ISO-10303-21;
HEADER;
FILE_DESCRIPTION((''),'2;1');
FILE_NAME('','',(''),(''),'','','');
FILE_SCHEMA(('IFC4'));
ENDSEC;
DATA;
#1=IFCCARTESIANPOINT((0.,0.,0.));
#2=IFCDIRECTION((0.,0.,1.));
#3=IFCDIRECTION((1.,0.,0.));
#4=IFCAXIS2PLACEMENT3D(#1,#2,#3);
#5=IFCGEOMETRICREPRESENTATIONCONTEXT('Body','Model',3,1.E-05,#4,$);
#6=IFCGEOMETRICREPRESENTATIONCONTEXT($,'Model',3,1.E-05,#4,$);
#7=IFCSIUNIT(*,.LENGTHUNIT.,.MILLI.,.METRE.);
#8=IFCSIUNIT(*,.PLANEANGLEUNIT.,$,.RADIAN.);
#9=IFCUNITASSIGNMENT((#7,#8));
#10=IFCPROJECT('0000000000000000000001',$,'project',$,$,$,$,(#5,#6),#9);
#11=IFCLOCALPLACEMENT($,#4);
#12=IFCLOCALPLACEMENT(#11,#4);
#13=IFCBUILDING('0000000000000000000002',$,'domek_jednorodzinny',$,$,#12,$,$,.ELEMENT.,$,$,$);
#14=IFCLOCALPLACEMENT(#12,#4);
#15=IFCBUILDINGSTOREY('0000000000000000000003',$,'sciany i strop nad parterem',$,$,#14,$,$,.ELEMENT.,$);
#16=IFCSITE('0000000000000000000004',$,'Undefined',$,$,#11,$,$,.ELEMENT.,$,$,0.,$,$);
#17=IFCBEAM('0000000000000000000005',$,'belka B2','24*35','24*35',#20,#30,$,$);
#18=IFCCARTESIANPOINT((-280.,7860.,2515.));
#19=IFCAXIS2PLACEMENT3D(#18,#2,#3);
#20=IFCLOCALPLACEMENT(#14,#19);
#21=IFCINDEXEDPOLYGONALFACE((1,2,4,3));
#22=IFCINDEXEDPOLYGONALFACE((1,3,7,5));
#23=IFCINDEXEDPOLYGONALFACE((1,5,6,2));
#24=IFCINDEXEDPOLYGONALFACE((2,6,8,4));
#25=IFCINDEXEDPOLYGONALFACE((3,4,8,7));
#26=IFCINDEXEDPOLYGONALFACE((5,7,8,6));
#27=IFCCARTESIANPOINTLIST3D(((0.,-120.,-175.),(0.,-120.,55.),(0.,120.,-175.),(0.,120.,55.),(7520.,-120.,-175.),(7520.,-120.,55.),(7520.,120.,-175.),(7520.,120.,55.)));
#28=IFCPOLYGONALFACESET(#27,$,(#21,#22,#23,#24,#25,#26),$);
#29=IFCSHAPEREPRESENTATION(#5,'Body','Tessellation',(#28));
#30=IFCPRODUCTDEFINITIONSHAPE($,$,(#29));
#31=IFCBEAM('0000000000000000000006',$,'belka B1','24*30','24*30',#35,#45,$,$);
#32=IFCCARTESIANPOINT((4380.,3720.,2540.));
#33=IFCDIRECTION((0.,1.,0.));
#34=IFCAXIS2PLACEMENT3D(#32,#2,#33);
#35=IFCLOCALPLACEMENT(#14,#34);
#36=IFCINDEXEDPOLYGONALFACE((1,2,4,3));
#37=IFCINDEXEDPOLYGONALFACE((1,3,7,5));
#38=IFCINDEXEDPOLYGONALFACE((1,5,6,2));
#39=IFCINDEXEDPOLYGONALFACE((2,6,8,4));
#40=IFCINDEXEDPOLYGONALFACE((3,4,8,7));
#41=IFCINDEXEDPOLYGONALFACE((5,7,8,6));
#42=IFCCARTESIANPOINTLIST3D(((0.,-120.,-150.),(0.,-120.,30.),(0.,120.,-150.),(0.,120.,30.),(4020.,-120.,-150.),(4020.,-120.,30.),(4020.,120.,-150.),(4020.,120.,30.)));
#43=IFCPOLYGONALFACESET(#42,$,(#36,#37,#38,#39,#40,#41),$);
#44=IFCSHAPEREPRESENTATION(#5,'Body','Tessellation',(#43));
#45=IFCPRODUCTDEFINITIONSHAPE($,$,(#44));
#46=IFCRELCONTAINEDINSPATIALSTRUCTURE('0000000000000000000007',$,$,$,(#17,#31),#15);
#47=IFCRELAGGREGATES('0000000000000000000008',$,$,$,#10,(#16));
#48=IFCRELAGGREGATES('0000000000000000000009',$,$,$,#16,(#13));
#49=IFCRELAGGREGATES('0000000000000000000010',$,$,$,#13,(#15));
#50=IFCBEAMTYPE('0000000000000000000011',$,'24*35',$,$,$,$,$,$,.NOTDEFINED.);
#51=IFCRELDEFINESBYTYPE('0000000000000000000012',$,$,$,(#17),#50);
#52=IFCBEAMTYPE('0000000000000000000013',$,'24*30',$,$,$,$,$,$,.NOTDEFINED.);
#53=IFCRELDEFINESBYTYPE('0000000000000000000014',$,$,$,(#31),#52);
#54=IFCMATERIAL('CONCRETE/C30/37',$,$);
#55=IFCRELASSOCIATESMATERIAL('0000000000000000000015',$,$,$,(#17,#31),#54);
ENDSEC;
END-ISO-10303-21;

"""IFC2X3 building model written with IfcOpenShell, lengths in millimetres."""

from ifc_helpers import new_model, si_unit, frame, origin_with_axes, origin_2d_with_axis, place, context, project, spatial, rectangle, extrude, clip, halfspace, material, type_object, element, save


model = new_model("IFC2X3")

# Units and contexts
model_context_1 = context("Model", 3, precision=1e-05, world=origin_with_axes(), identifier="Body")
model_context_2 = context("Model", 3, precision=1e-05, world=origin_with_axes())
ifc_project = project(units=[si_unit("LENGTHUNIT", "METRE", prefix="MILLI"), si_unit("PLANEANGLEUNIT", "RADIAN")], contexts=[model_context_1, model_context_2])

# Site, building, storey
site_placement = place(None, origin_with_axes())
site = spatial("IfcSite", under=ifc_project, at=site_placement, Name="Undefined", CompositionType="ELEMENT", RefElevation=0.0)
building_placement = place(site_placement, origin_with_axes())
building = spatial("IfcBuilding", under=site, at=building_placement, Name="domek_jednorodzinny", CompositionType="ELEMENT")
storey_placement = place(building_placement, origin_with_axes())
storey = spatial("IfcBuildingStorey", under=building, at=storey_placement, Name="sciany i strop nad parterem", CompositionType="ELEMENT")

# Shared definitions
ifc_material_1 = material(Name="CONCRETE/C30/37")

# Beams
beam_type_1 = type_object("IfcBeamType", Name="24*35", PredefinedType="NOTDEFINED")
beam_1_placement = place(storey_placement, frame((-280.0, 7860.0, 2515.0), z_axis=(0.0, 0.0, 1.0), x_axis=(1.0, 0.0, 0.0)))
element("IfcBeam", 1, at=beam_1_placement, inside=storey, type_object=beam_type_1, material=ifc_material_1, Name="belka B2", Description="24*35", ObjectType="24*35", context=model_context_1, shape_type="Clipping", body=[
    clip(extrude(rectangle(XDim=240.0, YDim=350.0, at=origin_2d_with_axis()), frame((7520.0, 0.0, 0.0), z_axis=(-1.0, 0.0, 0.0), x_axis=(0.0, -1.0, 0.0)), (0.0, 0.0, 1.0), 7520.0), halfspace(frame((7520.0, 120.0, 55.0), z_axis=(0.0, 0.0, 1.0), x_axis=(0.0, -1.0, 0.0)), False)),
])
beam_type_2 = type_object("IfcBeamType", Name="24*30", PredefinedType="NOTDEFINED")
beam_2_placement = place(storey_placement, frame((4380.0, 3720.0, 2540.0), z_axis=(0.0, 0.0, 1.0), x_axis=(0.0, 1.0, 0.0)))
element("IfcBeam", 2, at=beam_2_placement, inside=storey, type_object=beam_type_2, material=ifc_material_1, Name="belka B1", Description="24*30", ObjectType="24*30", context=model_context_1, shape_type="Clipping", body=[
    clip(extrude(rectangle(XDim=240.0, YDim=300.0, at=origin_2d_with_axis()), frame((4020.0, 0.0, 0.0), z_axis=(-1.0, 0.0, 0.0), x_axis=(0.0, -1.0, 0.0)), (0.0, 0.0, 1.0), 4020.0), halfspace(frame((4020.0, 120.0, 30.0), z_axis=(0.0, 0.0, 1.0), x_axis=(0.0, -1.0, 0.0)), False)),
])

save(model, "model.ifc")
